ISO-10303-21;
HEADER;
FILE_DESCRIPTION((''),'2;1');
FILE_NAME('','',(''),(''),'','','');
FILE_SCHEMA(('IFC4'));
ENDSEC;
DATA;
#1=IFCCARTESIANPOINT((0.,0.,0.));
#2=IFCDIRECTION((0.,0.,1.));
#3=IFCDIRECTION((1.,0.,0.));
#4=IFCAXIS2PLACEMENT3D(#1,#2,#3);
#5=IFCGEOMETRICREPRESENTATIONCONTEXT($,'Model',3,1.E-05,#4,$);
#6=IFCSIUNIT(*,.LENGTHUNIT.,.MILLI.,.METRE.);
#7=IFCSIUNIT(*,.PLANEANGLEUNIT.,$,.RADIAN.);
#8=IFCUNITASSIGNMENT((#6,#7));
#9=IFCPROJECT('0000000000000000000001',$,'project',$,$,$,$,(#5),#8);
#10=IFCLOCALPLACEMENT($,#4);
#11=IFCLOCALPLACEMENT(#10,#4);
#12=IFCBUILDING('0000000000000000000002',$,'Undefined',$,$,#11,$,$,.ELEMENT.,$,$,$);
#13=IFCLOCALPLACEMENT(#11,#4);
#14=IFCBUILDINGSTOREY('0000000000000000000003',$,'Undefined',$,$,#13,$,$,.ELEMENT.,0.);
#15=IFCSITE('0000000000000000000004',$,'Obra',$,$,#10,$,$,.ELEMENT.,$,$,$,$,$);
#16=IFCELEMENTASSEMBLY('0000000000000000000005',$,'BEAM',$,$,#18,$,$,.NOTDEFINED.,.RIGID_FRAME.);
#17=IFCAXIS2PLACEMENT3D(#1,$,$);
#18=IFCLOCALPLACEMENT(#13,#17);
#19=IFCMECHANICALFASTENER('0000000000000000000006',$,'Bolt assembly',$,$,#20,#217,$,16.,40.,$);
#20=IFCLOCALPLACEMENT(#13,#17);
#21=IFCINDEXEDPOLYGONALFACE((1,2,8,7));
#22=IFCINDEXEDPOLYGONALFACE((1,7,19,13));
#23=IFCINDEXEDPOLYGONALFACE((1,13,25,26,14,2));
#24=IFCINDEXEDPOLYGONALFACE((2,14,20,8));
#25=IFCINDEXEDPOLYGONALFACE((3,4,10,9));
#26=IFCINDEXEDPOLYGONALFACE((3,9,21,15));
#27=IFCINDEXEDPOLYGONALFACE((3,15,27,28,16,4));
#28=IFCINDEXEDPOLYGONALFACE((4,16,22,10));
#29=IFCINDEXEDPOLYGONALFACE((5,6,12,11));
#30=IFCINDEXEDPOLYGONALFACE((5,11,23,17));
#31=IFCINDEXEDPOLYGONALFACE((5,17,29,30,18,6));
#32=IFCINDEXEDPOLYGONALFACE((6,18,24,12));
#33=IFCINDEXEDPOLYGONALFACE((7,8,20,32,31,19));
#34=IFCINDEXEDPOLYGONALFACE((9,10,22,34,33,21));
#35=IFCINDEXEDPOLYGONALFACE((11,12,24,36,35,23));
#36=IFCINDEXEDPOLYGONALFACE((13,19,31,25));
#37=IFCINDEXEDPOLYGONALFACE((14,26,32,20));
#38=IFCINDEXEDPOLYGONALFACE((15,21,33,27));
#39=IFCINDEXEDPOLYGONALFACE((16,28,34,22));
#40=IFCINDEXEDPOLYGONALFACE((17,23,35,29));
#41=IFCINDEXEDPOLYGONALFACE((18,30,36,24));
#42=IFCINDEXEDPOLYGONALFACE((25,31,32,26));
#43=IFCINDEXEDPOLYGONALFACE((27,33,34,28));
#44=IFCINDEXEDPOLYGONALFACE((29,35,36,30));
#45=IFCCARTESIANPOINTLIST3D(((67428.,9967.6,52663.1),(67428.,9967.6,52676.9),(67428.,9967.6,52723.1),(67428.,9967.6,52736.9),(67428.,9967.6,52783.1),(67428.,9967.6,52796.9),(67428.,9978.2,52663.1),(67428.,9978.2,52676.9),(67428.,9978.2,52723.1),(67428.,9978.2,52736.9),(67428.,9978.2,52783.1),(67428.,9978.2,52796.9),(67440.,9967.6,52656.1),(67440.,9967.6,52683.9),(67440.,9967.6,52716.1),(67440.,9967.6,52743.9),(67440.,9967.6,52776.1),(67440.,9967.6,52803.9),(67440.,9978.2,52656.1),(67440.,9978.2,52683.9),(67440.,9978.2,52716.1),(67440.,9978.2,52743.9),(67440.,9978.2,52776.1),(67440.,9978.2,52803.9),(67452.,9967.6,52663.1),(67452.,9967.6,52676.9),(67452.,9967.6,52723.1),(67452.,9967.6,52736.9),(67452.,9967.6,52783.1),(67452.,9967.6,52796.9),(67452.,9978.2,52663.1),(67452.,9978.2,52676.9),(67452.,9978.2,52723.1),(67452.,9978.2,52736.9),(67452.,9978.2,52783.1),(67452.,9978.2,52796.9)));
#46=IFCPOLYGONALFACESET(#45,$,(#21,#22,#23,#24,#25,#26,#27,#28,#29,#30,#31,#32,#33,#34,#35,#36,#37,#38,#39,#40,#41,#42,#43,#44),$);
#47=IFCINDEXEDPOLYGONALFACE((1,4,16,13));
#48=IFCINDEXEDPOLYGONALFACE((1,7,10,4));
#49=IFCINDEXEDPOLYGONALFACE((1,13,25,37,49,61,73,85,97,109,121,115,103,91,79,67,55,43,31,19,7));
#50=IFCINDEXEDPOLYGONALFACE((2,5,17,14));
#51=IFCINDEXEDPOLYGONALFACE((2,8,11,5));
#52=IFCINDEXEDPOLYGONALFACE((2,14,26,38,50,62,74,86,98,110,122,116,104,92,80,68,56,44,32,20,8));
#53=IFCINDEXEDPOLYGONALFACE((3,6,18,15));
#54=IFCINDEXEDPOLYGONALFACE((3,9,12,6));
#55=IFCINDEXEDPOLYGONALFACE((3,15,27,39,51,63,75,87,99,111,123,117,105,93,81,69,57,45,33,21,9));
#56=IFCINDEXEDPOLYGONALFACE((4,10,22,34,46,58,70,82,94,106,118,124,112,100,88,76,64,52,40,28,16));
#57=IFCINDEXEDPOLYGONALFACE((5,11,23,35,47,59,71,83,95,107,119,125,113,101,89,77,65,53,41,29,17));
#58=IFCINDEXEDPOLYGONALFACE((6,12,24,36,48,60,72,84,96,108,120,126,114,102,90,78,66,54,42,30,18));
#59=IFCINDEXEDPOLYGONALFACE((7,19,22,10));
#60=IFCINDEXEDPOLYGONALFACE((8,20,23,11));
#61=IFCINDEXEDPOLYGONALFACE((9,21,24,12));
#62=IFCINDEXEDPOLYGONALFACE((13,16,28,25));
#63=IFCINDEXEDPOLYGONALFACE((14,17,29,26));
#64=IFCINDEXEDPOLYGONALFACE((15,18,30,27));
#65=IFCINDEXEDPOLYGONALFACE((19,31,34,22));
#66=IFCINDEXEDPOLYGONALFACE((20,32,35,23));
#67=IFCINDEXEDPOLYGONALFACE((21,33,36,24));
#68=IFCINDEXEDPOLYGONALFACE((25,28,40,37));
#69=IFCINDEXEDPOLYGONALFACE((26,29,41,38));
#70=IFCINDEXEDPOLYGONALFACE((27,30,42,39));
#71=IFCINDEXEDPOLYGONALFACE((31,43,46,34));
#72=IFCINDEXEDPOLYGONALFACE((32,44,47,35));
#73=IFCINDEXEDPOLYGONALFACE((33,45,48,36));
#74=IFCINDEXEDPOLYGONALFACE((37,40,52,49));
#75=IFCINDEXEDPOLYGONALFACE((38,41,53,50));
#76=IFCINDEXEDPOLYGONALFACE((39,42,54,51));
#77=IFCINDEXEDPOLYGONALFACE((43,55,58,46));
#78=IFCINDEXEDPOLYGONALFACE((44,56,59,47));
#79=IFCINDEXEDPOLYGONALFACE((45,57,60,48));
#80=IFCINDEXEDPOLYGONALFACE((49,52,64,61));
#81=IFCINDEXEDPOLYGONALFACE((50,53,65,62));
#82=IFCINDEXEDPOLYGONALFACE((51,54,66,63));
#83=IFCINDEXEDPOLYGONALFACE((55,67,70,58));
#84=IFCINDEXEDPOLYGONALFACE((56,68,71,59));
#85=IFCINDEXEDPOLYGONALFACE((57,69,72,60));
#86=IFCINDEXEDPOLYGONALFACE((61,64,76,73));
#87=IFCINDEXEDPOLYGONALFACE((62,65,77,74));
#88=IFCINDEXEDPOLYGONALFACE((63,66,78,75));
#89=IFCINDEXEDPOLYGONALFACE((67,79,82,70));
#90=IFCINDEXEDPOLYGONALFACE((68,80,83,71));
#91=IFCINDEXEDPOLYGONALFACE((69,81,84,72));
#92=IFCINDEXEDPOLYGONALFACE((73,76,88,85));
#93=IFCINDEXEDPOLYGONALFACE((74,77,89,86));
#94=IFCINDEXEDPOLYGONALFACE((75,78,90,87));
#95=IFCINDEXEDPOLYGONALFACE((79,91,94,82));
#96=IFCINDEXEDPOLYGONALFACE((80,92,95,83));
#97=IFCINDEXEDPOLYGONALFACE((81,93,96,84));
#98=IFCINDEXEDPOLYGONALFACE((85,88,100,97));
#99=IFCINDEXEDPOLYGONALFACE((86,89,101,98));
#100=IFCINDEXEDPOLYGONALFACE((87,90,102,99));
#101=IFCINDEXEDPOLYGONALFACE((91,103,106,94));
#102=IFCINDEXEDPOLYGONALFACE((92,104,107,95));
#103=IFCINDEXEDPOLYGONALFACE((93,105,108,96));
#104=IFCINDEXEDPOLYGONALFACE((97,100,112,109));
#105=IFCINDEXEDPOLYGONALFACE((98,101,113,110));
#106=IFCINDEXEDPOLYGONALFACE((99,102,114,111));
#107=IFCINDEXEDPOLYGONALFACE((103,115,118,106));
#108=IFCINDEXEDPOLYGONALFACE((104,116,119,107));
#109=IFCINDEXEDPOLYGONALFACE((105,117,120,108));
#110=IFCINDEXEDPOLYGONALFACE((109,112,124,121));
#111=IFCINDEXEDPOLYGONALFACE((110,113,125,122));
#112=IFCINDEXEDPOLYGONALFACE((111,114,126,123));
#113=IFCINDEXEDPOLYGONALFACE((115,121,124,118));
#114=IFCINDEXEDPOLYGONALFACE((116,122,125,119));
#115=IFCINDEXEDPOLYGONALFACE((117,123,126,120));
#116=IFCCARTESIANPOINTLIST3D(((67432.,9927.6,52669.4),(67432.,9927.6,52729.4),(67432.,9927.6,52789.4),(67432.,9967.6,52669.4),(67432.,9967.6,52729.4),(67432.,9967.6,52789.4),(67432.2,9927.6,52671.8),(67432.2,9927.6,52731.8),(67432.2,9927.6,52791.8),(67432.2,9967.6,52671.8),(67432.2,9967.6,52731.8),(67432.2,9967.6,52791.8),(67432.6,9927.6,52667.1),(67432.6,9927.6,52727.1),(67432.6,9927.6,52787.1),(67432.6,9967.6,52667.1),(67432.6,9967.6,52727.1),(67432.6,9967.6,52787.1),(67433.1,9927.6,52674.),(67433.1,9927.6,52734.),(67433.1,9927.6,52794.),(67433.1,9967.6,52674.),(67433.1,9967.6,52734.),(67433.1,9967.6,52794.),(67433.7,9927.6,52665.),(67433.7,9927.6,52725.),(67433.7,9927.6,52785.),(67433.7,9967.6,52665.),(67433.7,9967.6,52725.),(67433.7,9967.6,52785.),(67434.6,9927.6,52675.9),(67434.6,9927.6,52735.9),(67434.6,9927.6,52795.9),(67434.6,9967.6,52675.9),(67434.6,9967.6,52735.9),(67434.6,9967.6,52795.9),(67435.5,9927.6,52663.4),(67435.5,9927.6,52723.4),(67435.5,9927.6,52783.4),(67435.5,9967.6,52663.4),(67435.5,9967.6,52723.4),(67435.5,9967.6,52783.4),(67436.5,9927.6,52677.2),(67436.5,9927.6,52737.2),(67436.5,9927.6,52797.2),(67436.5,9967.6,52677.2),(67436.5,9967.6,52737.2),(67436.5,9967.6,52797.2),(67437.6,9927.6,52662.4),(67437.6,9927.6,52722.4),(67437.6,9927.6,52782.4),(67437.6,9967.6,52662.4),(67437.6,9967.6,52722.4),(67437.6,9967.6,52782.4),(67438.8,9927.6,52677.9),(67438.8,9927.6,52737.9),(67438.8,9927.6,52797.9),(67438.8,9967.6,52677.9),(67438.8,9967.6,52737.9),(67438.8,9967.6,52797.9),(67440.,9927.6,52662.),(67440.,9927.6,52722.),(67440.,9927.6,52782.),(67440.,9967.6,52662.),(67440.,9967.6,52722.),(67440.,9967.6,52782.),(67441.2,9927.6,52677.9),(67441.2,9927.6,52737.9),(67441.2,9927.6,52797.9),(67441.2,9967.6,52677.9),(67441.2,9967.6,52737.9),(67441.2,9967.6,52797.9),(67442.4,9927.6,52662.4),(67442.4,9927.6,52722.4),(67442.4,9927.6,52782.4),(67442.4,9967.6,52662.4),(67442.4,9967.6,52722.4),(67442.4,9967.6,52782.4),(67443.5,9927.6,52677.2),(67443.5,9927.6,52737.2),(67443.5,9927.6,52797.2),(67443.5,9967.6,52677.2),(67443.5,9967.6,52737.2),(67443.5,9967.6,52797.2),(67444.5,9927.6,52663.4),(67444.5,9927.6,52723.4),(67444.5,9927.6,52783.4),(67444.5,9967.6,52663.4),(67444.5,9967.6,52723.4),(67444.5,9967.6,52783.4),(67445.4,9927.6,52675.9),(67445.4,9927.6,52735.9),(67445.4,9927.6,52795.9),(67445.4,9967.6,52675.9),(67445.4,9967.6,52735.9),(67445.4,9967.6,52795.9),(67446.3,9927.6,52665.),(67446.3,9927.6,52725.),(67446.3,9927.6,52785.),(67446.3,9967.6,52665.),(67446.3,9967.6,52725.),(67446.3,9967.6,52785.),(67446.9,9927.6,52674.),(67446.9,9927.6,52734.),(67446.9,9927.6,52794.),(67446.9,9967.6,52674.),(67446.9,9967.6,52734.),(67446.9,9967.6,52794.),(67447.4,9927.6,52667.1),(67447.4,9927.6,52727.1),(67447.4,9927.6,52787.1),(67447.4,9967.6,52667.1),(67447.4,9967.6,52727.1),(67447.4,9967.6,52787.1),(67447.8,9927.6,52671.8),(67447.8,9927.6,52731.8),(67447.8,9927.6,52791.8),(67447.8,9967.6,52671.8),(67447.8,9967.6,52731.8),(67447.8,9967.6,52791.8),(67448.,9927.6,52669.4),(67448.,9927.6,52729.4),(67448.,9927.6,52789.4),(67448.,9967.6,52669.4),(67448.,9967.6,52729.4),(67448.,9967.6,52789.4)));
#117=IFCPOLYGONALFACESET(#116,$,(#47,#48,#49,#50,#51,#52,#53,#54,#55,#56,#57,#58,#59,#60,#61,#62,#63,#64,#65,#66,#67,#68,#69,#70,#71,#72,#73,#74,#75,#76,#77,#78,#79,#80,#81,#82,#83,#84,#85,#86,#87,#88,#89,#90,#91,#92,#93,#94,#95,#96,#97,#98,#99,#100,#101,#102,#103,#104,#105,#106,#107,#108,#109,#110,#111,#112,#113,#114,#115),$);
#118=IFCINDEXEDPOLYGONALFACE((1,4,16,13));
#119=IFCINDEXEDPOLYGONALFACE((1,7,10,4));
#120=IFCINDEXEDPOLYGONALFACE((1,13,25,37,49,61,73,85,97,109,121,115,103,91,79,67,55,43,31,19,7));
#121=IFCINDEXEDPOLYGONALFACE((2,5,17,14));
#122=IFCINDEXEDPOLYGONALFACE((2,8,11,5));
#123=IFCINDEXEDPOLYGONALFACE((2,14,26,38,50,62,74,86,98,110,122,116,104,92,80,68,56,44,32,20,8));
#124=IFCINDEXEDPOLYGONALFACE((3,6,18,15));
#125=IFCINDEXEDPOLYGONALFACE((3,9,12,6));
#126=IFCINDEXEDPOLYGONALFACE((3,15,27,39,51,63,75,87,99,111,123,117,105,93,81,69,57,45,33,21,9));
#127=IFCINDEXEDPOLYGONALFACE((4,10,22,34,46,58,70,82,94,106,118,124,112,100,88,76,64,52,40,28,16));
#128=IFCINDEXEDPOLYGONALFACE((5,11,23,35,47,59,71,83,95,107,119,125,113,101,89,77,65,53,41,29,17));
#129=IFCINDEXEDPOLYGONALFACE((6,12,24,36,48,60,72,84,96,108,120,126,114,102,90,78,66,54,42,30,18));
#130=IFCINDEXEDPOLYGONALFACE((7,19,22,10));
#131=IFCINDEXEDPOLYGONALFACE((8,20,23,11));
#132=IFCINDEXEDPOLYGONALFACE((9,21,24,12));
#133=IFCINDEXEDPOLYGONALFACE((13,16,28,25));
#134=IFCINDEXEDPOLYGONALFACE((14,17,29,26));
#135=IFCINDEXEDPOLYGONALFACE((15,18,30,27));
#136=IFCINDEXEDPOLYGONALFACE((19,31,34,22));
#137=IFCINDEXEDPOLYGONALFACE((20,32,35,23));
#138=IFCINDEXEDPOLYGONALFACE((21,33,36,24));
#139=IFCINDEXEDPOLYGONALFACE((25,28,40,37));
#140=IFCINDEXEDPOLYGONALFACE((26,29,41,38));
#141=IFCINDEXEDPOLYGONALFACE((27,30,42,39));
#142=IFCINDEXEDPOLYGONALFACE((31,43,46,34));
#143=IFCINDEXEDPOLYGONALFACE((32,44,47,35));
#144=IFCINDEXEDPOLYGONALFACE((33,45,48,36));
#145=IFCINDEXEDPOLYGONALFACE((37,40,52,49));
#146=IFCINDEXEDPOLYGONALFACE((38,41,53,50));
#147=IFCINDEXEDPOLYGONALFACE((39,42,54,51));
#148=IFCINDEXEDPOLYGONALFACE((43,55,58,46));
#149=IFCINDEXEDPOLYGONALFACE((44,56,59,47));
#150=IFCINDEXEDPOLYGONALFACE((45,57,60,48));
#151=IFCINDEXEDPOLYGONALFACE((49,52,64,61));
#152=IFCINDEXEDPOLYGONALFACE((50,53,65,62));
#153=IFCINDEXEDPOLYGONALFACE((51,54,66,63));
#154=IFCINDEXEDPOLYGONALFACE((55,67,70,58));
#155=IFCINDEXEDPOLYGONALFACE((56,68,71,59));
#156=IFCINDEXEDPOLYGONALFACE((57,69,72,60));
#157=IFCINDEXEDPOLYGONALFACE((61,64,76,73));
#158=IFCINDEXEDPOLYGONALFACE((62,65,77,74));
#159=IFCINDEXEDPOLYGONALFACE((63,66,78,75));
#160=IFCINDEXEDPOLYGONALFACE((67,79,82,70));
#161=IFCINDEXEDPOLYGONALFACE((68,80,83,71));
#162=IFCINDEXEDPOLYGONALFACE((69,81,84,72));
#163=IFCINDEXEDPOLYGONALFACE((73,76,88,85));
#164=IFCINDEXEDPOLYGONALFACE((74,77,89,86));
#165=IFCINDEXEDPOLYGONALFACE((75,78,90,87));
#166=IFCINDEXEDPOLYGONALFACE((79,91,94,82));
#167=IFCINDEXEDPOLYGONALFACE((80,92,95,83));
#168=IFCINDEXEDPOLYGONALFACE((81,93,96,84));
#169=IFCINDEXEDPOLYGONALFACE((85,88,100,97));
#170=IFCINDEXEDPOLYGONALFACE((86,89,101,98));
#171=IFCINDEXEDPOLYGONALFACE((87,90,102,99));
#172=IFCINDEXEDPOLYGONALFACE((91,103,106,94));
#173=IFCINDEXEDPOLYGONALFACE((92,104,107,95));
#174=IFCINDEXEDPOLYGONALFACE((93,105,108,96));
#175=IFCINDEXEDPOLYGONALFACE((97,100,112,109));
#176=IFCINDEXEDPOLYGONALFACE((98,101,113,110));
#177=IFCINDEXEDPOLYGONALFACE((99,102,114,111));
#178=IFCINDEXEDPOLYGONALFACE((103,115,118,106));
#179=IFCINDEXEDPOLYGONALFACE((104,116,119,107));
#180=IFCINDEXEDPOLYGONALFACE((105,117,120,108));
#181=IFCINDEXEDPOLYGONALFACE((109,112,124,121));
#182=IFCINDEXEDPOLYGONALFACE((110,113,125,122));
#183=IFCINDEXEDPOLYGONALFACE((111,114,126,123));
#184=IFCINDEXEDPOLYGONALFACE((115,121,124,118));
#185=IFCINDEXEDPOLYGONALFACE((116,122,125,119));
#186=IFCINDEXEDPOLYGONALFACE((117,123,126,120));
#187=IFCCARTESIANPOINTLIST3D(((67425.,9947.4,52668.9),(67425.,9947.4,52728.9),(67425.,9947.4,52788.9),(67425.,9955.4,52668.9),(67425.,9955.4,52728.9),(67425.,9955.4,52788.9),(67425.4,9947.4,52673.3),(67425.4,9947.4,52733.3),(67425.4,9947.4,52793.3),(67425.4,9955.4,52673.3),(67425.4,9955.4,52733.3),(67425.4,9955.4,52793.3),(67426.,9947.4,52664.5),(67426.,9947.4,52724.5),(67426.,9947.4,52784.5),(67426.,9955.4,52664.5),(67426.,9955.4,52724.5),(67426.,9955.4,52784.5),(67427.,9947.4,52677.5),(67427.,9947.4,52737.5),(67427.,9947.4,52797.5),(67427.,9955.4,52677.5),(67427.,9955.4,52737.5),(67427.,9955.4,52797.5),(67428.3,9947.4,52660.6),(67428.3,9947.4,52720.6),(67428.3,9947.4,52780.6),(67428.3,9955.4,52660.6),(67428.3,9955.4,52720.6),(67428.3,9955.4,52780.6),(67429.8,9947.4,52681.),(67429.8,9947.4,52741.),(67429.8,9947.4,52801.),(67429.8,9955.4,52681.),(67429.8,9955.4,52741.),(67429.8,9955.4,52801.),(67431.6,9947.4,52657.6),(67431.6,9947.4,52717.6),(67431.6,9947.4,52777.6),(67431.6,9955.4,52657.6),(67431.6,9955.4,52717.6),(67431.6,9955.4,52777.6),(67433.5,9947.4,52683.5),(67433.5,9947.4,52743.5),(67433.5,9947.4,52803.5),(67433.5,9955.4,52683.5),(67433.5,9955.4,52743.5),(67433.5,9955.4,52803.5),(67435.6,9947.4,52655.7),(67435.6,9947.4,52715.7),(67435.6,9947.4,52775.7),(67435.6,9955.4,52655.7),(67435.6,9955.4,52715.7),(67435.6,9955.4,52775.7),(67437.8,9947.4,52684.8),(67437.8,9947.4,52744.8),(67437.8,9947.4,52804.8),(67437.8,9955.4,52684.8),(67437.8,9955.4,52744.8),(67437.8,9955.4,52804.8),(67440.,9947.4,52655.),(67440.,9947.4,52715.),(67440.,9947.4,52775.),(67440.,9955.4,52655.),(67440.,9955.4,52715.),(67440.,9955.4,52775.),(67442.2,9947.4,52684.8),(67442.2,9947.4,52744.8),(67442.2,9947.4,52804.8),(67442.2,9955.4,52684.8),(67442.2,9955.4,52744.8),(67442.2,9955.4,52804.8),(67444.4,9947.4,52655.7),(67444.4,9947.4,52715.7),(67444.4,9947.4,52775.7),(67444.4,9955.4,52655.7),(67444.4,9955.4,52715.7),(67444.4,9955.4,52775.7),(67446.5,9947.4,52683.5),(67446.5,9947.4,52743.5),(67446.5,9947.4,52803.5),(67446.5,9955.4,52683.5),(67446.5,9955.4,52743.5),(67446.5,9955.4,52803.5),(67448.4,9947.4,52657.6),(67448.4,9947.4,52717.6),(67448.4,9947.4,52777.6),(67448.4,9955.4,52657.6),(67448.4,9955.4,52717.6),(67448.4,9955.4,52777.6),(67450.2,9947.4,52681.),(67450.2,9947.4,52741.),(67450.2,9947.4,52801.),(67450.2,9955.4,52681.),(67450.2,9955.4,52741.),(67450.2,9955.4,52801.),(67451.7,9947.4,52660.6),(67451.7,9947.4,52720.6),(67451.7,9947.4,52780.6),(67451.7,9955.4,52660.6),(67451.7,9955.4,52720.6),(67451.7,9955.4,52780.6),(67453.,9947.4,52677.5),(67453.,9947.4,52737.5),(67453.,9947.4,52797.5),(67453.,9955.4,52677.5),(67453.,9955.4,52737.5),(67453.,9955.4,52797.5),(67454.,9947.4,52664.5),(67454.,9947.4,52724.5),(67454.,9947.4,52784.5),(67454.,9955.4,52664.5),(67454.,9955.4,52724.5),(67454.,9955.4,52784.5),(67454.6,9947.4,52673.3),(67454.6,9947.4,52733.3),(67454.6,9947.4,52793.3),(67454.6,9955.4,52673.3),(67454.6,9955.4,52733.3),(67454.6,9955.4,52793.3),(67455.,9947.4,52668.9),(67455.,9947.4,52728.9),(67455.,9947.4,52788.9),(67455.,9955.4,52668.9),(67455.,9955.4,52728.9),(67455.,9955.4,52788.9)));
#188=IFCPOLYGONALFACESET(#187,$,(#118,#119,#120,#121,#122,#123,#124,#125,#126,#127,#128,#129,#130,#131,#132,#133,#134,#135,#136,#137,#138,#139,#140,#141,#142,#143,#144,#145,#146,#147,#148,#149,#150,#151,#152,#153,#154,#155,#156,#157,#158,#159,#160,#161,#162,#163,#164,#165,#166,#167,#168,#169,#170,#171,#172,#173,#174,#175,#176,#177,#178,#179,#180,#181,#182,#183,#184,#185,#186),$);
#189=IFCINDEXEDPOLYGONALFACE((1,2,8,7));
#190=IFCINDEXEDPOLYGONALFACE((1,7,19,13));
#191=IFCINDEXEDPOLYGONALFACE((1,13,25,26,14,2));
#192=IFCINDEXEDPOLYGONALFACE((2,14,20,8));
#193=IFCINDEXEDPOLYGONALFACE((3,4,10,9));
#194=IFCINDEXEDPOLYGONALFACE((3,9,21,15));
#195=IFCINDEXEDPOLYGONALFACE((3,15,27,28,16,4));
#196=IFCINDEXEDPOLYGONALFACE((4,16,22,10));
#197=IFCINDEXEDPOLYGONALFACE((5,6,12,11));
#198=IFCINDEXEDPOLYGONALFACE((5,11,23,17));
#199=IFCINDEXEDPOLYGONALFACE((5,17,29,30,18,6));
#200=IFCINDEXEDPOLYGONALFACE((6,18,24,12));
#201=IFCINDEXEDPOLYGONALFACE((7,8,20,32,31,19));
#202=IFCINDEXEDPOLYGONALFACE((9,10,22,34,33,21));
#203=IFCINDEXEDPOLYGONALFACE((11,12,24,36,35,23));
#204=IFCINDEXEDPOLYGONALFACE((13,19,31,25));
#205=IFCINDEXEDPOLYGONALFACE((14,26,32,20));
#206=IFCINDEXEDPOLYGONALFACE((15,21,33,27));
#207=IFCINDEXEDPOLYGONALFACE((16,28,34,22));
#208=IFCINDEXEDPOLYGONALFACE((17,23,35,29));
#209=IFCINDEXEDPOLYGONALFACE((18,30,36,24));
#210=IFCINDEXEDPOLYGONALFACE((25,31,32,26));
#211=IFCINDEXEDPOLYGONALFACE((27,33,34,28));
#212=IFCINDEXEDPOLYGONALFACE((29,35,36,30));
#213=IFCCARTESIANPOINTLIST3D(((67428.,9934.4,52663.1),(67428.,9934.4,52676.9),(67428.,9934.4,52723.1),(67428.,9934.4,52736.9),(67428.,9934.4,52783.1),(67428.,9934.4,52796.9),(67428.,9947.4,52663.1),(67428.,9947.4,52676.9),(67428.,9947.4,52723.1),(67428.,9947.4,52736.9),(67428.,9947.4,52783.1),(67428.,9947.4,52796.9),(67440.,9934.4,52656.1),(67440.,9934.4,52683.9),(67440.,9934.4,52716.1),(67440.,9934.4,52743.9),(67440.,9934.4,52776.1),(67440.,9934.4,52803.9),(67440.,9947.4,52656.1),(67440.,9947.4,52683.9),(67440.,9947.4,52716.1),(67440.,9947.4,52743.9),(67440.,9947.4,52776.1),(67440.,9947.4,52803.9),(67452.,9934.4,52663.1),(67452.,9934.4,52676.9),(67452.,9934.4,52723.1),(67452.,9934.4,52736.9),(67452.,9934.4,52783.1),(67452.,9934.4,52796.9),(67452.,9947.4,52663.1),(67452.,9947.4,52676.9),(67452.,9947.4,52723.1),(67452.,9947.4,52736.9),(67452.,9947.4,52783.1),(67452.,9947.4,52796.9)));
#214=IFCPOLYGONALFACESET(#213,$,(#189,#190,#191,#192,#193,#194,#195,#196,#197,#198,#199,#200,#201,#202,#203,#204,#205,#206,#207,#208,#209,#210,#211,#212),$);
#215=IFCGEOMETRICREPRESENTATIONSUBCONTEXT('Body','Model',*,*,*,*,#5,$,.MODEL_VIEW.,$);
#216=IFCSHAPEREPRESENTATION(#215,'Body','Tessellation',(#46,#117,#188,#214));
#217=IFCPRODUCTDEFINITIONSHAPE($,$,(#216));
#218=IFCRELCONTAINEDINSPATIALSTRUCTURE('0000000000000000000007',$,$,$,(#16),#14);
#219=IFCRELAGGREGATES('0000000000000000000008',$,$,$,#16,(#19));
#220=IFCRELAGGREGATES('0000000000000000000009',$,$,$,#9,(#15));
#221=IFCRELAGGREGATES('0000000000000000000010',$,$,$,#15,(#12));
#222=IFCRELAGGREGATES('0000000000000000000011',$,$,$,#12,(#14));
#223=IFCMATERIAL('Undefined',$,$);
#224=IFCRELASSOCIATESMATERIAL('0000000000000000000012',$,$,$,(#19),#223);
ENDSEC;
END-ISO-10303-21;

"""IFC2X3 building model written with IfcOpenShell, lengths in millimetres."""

from ifc_helpers import new_model, si_unit, frame, origin_with_axes, origin_2d_with_axis, place, context, subcontext, project, spatial, polyline, circle, outline, extrude, source, transform, mapped, material, element, aggregate, save


model = new_model("IFC2X3")

# Units and contexts
model_context = context("Model", 3, precision=1e-05, world=origin_with_axes())
body_context = subcontext(model_context, "Body", "Model", "MODEL_VIEW")
ifc_project = project(units=[si_unit("LENGTHUNIT", "METRE", prefix="MILLI"), si_unit("PLANEANGLEUNIT", "RADIAN")], contexts=[model_context])

# Site, building, storey
site_placement = place(None, origin_with_axes())
site = spatial("IfcSite", under=ifc_project, at=site_placement, Name="Obra", CompositionType="ELEMENT")
building_placement = place(site_placement, origin_with_axes())
building = spatial("IfcBuilding", under=site, at=building_placement, Name="Undefined", CompositionType="ELEMENT")
storey_placement = place(building_placement, origin_with_axes())
storey = spatial("IfcBuildingStorey", under=building, at=storey_placement, Name="Undefined", CompositionType="ELEMENT", Elevation=0.0)

# Element assembly, mechanical fastener
ifc_material_1 = material(Name="Undefined")
assembly_1_placement = place(storey_placement, origin_with_axes())
assembly_1 = element("IfcElementAssembly", 1, at=assembly_1_placement, inside=storey, Name="BEAM", AssemblyPlace="NOTDEFINED", PredefinedType="RIGID_FRAME")
shared_shape_1 = source(origin_with_axes(), body_context, "Body", "SweptSolid", [
    extrude(outline(polyline([(13.9, 0.0), (6.9, 12.0), (-6.9, 12.0), (-13.9, 0.0), (-6.9, -12.0), (6.9, -12.0), (13.9, 0.0)])), frame((0.0, -19.7, 0.0), z_axis=(0.0, 1.0, 0.0), x_axis=(1.0, 0.0, 0.0)), (0.0, 0.0, 1.0), 10.6),
    extrude(circle(Radius=8.0, at=origin_2d_with_axis()), frame((0.0, -9.1, 0.0), z_axis=(0.0, 1.0, 0.0), x_axis=(1.0, 0.0, 0.0)), (0.0, 0.0, 1.0), 40.0),
    extrude(circle(Radius=15.0, at=origin_2d_with_axis()), frame((0.0, 3.1, 0.0), z_axis=(0.0, 1.0, 0.0), x_axis=(1.0, 0.0, 0.0)), (0.0, 0.0, 1.0), 8.0),
    extrude(outline(polyline([(13.9, 0.0), (6.9, 12.0), (-6.9, 12.0), (-13.9, 0.0), (-6.9, -12.0), (6.9, -12.0), (13.9, 0.0)])), frame((0.0, 11.1, 0.0), z_axis=(0.0, 1.0, 0.0), x_axis=(1.0, 0.0, 0.0)), (0.0, 0.0, 1.0), 13.0),
])
mechanical_fastener_1_placement = place(assembly_1_placement, frame((67490.0, 9958.5, 52850.0), z_axis=(-1.0, 0.0, 0.0), x_axis=(0.0, 0.0, -1.0)))
mechanical_fastener_1 = element("IfcMechanicalFastener", 2, at=mechanical_fastener_1_placement, material=ifc_material_1, Name="Bolt assembly", NominalDiameter=16.0, NominalLength=40.0, context=body_context, shape_type="MappedRepresentation", body=[
    mapped(shared_shape_1, transform((60.0, 0.0, 50.0))),
    mapped(shared_shape_1, transform((120.0, 0.0, 50.0))),
    mapped(shared_shape_1, transform((180.0, 0.0, 50.0))),
])
aggregate(assembly_1, [mechanical_fastener_1])

save(model, "model.ifc")
